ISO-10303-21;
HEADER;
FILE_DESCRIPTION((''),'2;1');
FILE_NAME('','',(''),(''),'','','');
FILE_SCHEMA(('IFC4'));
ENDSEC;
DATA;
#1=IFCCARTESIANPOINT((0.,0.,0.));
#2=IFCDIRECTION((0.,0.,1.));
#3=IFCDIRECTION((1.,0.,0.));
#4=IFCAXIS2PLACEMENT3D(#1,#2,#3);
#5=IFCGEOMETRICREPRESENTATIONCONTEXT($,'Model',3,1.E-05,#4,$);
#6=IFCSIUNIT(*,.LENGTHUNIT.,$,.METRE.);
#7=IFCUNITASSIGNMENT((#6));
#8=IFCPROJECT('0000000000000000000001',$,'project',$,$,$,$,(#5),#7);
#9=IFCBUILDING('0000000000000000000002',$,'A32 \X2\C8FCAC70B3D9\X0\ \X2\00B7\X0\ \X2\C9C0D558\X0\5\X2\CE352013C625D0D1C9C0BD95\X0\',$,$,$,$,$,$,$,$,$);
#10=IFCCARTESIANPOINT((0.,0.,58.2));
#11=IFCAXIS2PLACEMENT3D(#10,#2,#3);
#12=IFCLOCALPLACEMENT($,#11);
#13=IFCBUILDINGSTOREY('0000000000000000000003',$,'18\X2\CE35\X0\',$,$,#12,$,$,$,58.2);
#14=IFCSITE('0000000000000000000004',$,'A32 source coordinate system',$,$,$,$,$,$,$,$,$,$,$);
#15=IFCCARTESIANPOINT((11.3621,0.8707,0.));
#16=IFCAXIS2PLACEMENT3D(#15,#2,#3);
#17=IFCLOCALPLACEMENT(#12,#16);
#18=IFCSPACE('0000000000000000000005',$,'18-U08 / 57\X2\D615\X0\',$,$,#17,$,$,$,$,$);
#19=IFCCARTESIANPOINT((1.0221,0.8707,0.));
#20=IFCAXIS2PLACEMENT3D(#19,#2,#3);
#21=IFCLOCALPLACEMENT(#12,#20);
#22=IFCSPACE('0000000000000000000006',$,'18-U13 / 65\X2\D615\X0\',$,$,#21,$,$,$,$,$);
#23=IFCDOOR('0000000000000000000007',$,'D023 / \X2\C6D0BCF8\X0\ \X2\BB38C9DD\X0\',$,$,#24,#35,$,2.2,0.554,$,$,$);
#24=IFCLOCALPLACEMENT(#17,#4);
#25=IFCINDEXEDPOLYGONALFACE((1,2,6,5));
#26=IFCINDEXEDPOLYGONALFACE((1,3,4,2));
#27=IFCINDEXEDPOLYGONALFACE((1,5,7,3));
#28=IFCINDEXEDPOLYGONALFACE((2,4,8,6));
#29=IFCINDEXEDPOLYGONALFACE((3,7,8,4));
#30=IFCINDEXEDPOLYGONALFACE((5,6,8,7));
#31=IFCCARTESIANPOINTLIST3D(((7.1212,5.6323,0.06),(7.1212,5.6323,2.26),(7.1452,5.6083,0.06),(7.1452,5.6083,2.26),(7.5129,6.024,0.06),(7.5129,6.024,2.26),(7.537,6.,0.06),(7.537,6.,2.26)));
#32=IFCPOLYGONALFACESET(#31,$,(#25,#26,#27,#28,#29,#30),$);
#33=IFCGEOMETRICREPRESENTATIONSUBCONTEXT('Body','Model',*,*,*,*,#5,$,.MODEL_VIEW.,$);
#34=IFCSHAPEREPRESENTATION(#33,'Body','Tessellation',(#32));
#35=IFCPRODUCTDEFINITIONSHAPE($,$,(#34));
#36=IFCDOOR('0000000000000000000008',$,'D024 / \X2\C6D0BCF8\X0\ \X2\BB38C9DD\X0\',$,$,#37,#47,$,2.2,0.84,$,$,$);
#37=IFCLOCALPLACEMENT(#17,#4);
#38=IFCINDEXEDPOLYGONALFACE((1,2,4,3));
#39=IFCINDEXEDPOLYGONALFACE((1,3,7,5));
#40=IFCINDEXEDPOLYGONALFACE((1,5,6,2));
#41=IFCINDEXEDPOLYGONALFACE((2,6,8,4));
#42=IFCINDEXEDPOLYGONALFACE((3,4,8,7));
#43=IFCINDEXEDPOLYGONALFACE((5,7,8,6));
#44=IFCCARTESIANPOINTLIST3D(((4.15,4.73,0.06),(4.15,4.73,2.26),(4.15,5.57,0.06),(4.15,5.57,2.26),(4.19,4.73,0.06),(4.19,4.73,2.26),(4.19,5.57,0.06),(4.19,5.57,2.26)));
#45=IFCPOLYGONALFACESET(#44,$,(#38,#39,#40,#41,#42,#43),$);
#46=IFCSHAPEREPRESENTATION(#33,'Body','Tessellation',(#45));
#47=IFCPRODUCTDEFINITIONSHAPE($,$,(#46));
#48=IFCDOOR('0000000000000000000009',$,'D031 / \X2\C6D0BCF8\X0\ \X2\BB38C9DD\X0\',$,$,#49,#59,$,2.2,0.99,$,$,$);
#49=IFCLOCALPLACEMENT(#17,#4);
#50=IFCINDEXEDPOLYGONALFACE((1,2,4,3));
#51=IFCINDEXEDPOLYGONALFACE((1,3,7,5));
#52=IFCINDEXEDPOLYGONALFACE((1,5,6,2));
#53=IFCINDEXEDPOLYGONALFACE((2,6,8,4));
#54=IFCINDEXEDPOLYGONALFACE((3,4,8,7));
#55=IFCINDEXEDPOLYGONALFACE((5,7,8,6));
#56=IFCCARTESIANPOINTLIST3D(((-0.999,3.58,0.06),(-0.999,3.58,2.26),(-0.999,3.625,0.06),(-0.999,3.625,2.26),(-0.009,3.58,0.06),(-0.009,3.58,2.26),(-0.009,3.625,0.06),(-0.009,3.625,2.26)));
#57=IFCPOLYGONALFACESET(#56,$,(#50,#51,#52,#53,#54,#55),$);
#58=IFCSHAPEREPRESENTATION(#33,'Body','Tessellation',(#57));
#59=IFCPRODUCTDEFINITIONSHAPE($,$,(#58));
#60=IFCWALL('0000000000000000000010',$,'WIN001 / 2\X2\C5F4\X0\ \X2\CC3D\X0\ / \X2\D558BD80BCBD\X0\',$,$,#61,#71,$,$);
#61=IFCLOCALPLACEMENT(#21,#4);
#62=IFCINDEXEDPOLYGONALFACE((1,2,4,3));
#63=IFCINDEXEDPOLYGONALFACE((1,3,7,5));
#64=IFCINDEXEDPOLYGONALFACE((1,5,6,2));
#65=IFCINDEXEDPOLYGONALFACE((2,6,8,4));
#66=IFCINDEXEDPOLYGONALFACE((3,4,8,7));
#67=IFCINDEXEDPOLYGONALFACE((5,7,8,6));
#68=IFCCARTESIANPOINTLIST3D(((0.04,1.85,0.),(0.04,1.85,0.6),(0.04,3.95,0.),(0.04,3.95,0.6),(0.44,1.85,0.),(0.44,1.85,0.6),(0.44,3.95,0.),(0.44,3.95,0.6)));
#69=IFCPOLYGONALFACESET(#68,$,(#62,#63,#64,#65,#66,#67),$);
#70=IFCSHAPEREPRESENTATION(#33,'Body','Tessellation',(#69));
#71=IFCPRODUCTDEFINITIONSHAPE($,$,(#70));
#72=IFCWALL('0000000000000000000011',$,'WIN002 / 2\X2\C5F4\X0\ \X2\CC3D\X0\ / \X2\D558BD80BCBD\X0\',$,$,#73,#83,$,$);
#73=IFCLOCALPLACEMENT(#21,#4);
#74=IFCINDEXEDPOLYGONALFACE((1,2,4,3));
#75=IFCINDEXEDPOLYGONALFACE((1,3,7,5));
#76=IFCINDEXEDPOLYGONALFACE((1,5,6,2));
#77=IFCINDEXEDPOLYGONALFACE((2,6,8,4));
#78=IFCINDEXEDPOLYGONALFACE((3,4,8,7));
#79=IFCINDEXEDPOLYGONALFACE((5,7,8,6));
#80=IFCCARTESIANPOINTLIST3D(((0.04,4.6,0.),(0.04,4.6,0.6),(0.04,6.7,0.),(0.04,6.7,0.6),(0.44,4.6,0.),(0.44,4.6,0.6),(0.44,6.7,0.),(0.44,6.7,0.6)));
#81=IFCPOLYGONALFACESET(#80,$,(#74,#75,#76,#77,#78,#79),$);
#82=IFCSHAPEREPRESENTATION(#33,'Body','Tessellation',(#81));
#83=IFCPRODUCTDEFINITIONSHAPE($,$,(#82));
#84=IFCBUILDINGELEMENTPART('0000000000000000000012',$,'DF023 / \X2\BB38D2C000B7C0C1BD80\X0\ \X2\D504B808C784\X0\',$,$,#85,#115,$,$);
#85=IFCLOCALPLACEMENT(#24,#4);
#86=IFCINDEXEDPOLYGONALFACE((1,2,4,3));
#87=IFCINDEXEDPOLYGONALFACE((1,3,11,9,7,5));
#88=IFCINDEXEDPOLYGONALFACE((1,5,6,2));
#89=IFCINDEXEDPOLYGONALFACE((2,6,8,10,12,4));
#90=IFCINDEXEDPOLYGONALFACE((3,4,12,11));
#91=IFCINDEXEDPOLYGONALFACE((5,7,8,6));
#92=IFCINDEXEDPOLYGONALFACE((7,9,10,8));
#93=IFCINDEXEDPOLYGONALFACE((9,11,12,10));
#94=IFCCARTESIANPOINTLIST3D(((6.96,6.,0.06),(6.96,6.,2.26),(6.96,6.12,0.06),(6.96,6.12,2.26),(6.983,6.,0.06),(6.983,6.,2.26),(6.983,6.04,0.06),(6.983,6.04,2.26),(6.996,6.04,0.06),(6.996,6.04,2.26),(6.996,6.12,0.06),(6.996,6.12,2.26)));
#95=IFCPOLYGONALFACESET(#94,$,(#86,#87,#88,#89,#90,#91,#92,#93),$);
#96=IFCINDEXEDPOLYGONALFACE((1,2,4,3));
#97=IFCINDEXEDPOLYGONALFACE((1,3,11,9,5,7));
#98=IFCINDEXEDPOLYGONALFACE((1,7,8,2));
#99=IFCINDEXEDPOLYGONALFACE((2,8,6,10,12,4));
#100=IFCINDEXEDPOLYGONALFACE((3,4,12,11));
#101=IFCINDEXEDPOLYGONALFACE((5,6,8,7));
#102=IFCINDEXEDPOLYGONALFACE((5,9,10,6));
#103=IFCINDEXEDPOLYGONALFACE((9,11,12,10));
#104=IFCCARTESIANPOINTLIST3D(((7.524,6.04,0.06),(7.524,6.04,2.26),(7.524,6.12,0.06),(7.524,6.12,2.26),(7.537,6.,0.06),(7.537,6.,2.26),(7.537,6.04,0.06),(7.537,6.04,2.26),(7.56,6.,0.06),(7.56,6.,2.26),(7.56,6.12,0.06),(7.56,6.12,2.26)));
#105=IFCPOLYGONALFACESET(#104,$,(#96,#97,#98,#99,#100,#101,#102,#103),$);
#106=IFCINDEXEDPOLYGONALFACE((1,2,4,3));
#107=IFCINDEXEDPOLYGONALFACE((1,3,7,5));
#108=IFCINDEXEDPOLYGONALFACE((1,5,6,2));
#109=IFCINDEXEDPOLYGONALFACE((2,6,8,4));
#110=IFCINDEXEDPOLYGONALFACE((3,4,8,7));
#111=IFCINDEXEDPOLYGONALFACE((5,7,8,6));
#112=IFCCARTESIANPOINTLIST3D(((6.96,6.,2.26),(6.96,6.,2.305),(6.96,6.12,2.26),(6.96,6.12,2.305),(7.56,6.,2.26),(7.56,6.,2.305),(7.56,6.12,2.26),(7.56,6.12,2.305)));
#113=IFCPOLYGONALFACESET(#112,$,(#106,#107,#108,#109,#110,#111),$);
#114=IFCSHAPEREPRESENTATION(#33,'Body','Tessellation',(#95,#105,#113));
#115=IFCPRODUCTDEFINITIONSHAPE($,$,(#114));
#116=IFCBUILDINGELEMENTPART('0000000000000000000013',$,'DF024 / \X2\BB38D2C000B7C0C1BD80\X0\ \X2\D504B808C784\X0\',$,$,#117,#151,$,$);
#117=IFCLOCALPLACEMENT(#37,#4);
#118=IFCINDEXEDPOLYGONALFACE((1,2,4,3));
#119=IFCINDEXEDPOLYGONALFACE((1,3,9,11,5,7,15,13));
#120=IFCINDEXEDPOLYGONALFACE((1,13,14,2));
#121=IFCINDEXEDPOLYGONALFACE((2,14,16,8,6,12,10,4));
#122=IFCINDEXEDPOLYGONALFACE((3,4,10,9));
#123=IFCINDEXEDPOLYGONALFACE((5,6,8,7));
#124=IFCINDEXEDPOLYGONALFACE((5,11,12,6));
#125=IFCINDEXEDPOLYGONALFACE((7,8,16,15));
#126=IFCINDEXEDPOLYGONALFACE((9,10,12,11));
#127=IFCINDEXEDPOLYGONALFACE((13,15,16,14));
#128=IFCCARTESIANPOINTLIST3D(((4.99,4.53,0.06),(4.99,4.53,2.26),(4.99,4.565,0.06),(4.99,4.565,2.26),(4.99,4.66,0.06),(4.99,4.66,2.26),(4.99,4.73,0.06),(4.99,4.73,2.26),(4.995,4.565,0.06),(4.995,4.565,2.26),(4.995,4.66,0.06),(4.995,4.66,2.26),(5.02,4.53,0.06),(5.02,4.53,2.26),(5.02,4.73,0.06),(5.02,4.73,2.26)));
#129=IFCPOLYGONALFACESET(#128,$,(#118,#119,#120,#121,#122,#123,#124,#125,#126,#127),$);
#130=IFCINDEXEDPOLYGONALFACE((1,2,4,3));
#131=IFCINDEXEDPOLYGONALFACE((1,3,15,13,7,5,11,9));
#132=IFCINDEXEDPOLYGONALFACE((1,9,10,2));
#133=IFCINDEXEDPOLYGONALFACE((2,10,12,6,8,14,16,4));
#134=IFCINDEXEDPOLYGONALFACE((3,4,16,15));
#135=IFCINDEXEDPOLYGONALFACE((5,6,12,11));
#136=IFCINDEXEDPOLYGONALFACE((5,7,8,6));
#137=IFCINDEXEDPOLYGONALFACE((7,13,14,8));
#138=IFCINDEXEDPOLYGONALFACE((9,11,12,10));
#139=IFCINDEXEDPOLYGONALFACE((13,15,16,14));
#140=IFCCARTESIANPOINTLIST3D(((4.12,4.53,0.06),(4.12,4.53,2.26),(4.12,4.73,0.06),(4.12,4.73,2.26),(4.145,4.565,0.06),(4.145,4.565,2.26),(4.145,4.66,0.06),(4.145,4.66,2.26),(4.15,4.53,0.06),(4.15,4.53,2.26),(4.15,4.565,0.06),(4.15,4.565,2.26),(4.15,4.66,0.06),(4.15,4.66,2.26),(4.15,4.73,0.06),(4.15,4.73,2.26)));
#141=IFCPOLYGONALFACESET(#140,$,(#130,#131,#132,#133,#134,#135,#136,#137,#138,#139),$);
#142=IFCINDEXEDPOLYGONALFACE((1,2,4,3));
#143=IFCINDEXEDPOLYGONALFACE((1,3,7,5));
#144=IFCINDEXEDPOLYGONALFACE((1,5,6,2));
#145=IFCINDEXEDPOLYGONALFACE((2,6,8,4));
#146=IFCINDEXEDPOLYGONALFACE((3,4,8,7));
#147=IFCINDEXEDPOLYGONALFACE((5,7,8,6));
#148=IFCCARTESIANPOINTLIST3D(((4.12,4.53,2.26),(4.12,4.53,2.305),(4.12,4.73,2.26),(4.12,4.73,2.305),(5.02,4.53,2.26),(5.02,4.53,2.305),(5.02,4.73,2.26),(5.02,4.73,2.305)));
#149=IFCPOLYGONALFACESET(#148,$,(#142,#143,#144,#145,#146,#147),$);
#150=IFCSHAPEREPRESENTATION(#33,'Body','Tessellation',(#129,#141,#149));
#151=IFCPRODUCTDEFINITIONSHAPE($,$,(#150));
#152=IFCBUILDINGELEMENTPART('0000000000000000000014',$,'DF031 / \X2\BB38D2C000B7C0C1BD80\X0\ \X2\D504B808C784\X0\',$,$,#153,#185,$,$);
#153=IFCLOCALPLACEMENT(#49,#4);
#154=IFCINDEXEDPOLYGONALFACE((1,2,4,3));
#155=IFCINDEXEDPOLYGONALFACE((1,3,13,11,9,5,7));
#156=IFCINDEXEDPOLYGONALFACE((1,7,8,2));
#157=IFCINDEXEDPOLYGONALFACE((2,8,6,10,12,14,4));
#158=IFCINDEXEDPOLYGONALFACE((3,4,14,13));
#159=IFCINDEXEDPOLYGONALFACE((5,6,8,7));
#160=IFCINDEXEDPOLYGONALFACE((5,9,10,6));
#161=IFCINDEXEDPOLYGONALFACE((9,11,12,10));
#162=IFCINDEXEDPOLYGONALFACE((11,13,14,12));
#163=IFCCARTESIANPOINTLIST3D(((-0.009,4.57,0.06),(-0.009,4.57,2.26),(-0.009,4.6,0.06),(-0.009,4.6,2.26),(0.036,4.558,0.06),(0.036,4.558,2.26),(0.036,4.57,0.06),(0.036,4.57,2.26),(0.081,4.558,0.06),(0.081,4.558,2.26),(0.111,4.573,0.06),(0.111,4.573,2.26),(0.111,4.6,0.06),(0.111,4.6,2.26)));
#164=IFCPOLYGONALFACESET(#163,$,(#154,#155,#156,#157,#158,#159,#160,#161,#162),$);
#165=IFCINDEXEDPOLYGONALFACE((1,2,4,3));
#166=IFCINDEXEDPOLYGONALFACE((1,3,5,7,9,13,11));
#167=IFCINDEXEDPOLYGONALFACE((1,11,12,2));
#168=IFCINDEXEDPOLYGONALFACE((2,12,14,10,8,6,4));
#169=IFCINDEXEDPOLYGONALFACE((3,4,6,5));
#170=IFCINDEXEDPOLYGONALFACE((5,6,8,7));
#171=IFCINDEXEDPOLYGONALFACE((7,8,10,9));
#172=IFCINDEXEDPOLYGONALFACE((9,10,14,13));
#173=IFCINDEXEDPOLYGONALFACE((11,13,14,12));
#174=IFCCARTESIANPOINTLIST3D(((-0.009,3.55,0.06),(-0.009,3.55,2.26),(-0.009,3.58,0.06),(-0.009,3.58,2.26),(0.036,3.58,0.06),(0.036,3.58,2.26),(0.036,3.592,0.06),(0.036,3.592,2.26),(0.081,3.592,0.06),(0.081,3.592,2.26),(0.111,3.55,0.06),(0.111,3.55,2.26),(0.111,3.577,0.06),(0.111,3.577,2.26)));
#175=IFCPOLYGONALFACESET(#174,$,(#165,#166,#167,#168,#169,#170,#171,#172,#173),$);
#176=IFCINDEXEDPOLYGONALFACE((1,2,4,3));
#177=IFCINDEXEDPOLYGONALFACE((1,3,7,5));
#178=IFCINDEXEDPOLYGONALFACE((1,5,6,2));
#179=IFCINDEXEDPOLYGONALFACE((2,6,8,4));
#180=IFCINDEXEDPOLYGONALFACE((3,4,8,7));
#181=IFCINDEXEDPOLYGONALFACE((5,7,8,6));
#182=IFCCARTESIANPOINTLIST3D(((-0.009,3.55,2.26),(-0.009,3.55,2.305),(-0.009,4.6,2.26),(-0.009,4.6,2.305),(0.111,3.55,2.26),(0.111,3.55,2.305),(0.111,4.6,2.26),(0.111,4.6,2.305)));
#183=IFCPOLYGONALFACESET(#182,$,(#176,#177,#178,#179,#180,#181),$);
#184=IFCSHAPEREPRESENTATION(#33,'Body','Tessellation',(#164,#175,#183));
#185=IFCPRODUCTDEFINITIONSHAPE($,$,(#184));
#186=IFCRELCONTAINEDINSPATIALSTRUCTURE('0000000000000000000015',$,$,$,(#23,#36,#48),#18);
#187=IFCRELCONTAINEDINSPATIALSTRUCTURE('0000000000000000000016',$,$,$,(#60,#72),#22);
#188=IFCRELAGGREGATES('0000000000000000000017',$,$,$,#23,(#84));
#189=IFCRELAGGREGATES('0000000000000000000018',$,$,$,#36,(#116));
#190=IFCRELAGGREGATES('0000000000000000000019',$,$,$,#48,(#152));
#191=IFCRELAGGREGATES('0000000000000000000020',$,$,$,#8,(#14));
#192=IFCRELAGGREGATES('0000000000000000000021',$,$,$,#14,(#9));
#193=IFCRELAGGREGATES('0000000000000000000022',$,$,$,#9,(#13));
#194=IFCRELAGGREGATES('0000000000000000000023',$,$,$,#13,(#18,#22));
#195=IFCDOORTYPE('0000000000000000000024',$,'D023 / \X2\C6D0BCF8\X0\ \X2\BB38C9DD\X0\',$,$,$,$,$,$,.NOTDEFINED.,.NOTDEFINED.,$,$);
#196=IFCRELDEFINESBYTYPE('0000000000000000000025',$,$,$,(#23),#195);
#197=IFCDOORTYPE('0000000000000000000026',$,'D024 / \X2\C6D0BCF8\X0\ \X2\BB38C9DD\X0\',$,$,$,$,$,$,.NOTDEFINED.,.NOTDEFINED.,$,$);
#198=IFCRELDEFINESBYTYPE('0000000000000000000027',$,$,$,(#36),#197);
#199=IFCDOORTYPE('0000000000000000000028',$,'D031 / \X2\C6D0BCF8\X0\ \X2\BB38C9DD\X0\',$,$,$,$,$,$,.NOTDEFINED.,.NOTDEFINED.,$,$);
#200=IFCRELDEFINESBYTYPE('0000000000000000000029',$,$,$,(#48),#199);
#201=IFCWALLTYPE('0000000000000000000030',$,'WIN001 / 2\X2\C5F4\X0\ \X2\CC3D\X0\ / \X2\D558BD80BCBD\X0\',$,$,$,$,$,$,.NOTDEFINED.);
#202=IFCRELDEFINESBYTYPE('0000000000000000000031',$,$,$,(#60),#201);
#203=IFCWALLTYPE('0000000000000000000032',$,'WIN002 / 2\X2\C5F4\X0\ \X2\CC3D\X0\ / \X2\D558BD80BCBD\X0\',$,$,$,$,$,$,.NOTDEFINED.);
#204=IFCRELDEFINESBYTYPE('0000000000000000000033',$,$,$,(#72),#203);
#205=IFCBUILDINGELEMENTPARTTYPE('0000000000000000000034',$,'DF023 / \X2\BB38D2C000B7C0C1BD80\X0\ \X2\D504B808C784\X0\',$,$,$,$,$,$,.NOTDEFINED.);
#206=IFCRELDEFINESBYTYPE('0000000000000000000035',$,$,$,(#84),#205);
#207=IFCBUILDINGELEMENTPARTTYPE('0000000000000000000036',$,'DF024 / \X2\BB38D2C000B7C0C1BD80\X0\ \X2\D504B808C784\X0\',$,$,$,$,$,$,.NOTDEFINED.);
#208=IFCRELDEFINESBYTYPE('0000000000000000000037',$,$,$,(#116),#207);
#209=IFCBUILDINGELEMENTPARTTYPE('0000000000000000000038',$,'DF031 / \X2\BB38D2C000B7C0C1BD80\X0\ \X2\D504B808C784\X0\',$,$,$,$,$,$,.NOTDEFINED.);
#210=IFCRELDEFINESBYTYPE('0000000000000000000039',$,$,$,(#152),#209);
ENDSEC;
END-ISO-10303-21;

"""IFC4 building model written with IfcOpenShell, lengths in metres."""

from ifc_helpers import new_model, si_unit, frame, origin, origin_with_axes, place, context, subcontext, project, spatial, polyline, outline, extrude, source, transform, mapped, type_object, type_shapes, element, aggregate, save


model = new_model("IFC4")

# Units and contexts
model_context = context("Model", 3, precision=1e-05, world=origin_with_axes())
body_context = subcontext(model_context, "Body", "Model", "MODEL_VIEW")
ifc_project = project(units=[si_unit("LENGTHUNIT", "METRE")], contexts=[model_context])

# Site, building, storey, space
site = spatial("IfcSite", under=ifc_project, Name="A32 source coordinate system")
building = spatial("IfcBuilding", under=site, Name="A32 주거동 · 지하5층–옥탑지붕")
storey_placement = place(None, frame((0.0, 0.0, 58.2), z_axis=(0.0, 0.0, 1.0), x_axis=(1.0, 0.0, 0.0)))
storey = spatial("IfcBuildingStorey", under=building, at=storey_placement, Name="18층", Elevation=58.2)
space_1_placement = place(storey_placement, frame((11.3621, 0.8707, 0.0), z_axis=(0.0, 0.0, 1.0), x_axis=(1.0, 0.0, 0.0)))
space_1 = spatial("IfcSpace", under=storey, at=space_1_placement, Name="18-U08 / 57형")

# Doors
door_type_1 = type_object("IfcDoorType", Name="D023 / 원본 문짝", OperationType="NOTDEFINED", PredefinedType="NOTDEFINED")
shared_shape_1 = source(origin(), body_context, "Body", "SweptSolid", [
    extrude(outline(polyline([(7.537, 6.0), (7.1452, 5.6083), (7.1212, 5.6323), (7.5129, 6.024), (7.537, 6.0)])), frame((0.0, 0.0, 0.06)), (0.0, 0.0, 1.0), 2.2),
])
type_shapes(door_type_1, [shared_shape_1])
door_1_placement = place(space_1_placement, origin_with_axes())
door_1 = element("IfcDoor", 1, at=door_1_placement, inside=space_1, type_object=door_type_1, Name="D023 / 원본 문짝", OverallHeight=2.2, OverallWidth=0.554, context=body_context, shape_type="MappedRepresentation", body=[
    mapped(shared_shape_1, transform((0.0, 0.0, 0.0), scale=1.0)),
])
door_type_2 = type_object("IfcDoorType", Name="D024 / 원본 문짝", OperationType="NOTDEFINED", PredefinedType="NOTDEFINED")
shared_shape_2 = source(origin(), body_context, "Body", "SweptSolid", [
    extrude(outline(polyline([(4.15, 4.73), (4.15, 5.57), (4.19, 5.57), (4.19, 4.73), (4.15, 4.73)])), frame((0.0, 0.0, 0.06)), (0.0, 0.0, 1.0), 2.2),
])
type_shapes(door_type_2, [shared_shape_2])
door_2_placement = place(space_1_placement, origin_with_axes())
door_2 = element("IfcDoor", 2, at=door_2_placement, inside=space_1, type_object=door_type_2, Name="D024 / 원본 문짝", OverallHeight=2.2, OverallWidth=0.84, context=body_context, shape_type="MappedRepresentation", body=[
    mapped(shared_shape_2, transform((0.0, 0.0, 0.0), scale=1.0)),
])
door_type_3 = type_object("IfcDoorType", Name="D031 / 원본 문짝", OperationType="NOTDEFINED", PredefinedType="NOTDEFINED")
shared_shape_3 = source(origin(), body_context, "Body", "SweptSolid", [
    extrude(outline(polyline([(-0.009, 3.58), (-0.999, 3.58), (-0.999, 3.625), (-0.009, 3.625), (-0.009, 3.58)])), frame((0.0, 0.0, 0.06)), (0.0, 0.0, 1.0), 2.2),
])
type_shapes(door_type_3, [shared_shape_3])
door_3_placement = place(space_1_placement, origin_with_axes())
door_3 = element("IfcDoor", 3, at=door_3_placement, inside=space_1, type_object=door_type_3, Name="D031 / 원본 문짝", OverallHeight=2.2, OverallWidth=0.99, context=body_context, shape_type="MappedRepresentation", body=[
    mapped(shared_shape_3, transform((0.0, 0.0, 0.0), scale=1.0)),
])

# Shared definitions
space_2_placement = place(storey_placement, frame((1.0221, 0.8707, 0.0), z_axis=(0.0, 0.0, 1.0), x_axis=(1.0, 0.0, 0.0)))
space_2 = spatial("IfcSpace", under=storey, at=space_2_placement, Name="18-U13 / 65형")

# Walls
wall_type_1 = type_object("IfcWallType", Name="WIN001 / 2열 창 / 하부벽", PredefinedType="NOTDEFINED")
shared_shape_4 = source(origin(), body_context, "Body", "SweptSolid", [
    extrude(outline(polyline([(0.04, 3.95), (0.44, 3.95), (0.44, 1.85), (0.04, 1.85), (0.04, 3.95)])), origin(), (0.0, 0.0, 1.0), 0.6),
])
type_shapes(wall_type_1, [shared_shape_4])
wall_1_placement = place(space_2_placement, origin_with_axes())
element("IfcWall", 4, at=wall_1_placement, inside=space_2, type_object=wall_type_1, Name="WIN001 / 2열 창 / 하부벽", context=body_context, shape_type="MappedRepresentation", body=[
    mapped(shared_shape_4, transform((0.0, 0.0, 0.0), scale=1.0)),
])
wall_type_2 = type_object("IfcWallType", Name="WIN002 / 2열 창 / 하부벽", PredefinedType="NOTDEFINED")
shared_shape_5 = source(origin(), body_context, "Body", "SweptSolid", [
    extrude(outline(polyline([(0.04, 6.7), (0.44, 6.7), (0.44, 4.6), (0.04, 4.6), (0.04, 6.7)])), origin(), (0.0, 0.0, 1.0), 0.6),
])
type_shapes(wall_type_2, [shared_shape_5])
wall_2_placement = place(space_2_placement, origin_with_axes())
element("IfcWall", 5, at=wall_2_placement, inside=space_2, type_object=wall_type_2, Name="WIN002 / 2열 창 / 하부벽", context=body_context, shape_type="MappedRepresentation", body=[
    mapped(shared_shape_5, transform((0.0, 0.0, 0.0), scale=1.0)),
])

# Building element parts
building_element_part_type_1 = type_object("IfcBuildingElementPartType", Name="DF023 / 문틀·상부 프레임", PredefinedType="NOTDEFINED")
shared_shape_6 = source(origin(), body_context, "Body", "SweptSolid", [
    extrude(outline(polyline([(6.996, 6.12), (6.996, 6.04), (6.983, 6.04), (6.983, 6.0), (6.96, 6.0), (6.96, 6.12), (6.996, 6.12)])), frame((0.0, 0.0, 0.06)), (0.0, 0.0, 1.0), 2.2),
    extrude(outline(polyline([(7.56, 6.0), (7.537, 6.0), (7.537, 6.04), (7.524, 6.04), (7.524, 6.12), (7.56, 6.12), (7.56, 6.0)])), frame((0.0, 0.0, 0.06)), (0.0, 0.0, 1.0), 2.2),
    extrude(outline(polyline([(6.96, 6.0), (6.96, 6.12), (7.56, 6.12), (7.56, 6.0), (6.96, 6.0)])), frame((0.0, 0.0, 2.26)), (0.0, 0.0, 1.0), 0.045),
])
type_shapes(building_element_part_type_1, [shared_shape_6])
building_element_part_1_placement = place(door_1_placement, origin_with_axes())
building_element_part_1 = element("IfcBuildingElementPart", 6, at=building_element_part_1_placement, type_object=building_element_part_type_1, Name="DF023 / 문틀·상부 프레임", context=body_context, shape_type="MappedRepresentation", body=[
    mapped(shared_shape_6, transform((0.0, 0.0, 0.0), scale=1.0)),
])
aggregate(door_1, [building_element_part_1])
building_element_part_type_2 = type_object("IfcBuildingElementPartType", Name="DF024 / 문틀·상부 프레임", PredefinedType="NOTDEFINED")
shared_shape_7 = source(origin(), body_context, "Body", "SweptSolid", [
    extrude(outline(polyline([(5.02, 4.53), (4.99, 4.53), (4.99, 4.565), (4.995, 4.565), (4.995, 4.66), (4.99, 4.66), (4.99, 4.73), (5.02, 4.73), (5.02, 4.53)])), frame((0.0, 0.0, 0.06)), (0.0, 0.0, 1.0), 2.2),
    extrude(outline(polyline([(4.15, 4.73), (4.15, 4.66), (4.145, 4.66), (4.145, 4.565), (4.15, 4.565), (4.15, 4.53), (4.12, 4.53), (4.12, 4.73), (4.15, 4.73)])), frame((0.0, 0.0, 0.06)), (0.0, 0.0, 1.0), 2.2),
    extrude(outline(polyline([(4.12, 4.53), (4.12, 4.73), (5.02, 4.73), (5.02, 4.53), (4.12, 4.53)])), frame((0.0, 0.0, 2.26)), (0.0, 0.0, 1.0), 0.045),
])
type_shapes(building_element_part_type_2, [shared_shape_7])
building_element_part_2_placement = place(door_2_placement, origin_with_axes())
building_element_part_2 = element("IfcBuildingElementPart", 7, at=building_element_part_2_placement, type_object=building_element_part_type_2, Name="DF024 / 문틀·상부 프레임", context=body_context, shape_type="MappedRepresentation", body=[
    mapped(shared_shape_7, transform((0.0, 0.0, 0.0), scale=1.0)),
])
aggregate(door_2, [building_element_part_2])
building_element_part_type_3 = type_object("IfcBuildingElementPartType", Name="DF031 / 문틀·상부 프레임", PredefinedType="NOTDEFINED")
shared_shape_8 = source(origin(), body_context, "Body", "SweptSolid", [
    extrude(outline(polyline([(0.111, 4.6), (0.111, 4.573), (0.081, 4.558), (0.036, 4.558), (0.036, 4.57), (-0.009, 4.57), (-0.009, 4.6), (0.111, 4.6)])), frame((0.0, 0.0, 0.06)), (0.0, 0.0, 1.0), 2.2),
    extrude(outline(polyline([(-0.009, 3.58), (0.036, 3.58), (0.036, 3.592), (0.081, 3.592), (0.111, 3.577), (0.111, 3.55), (-0.009, 3.55), (-0.009, 3.58)])), frame((0.0, 0.0, 0.06)), (0.0, 0.0, 1.0), 2.2),
    extrude(outline(polyline([(-0.009, 3.55), (-0.009, 4.6), (0.111, 4.6), (0.111, 3.55), (-0.009, 3.55)])), frame((0.0, 0.0, 2.26)), (0.0, 0.0, 1.0), 0.045),
])
type_shapes(building_element_part_type_3, [shared_shape_8])
building_element_part_3_placement = place(door_3_placement, origin_with_axes())
building_element_part_3 = element("IfcBuildingElementPart", 8, at=building_element_part_3_placement, type_object=building_element_part_type_3, Name="DF031 / 문틀·상부 프레임", context=body_context, shape_type="MappedRepresentation", body=[
    mapped(shared_shape_8, transform((0.0, 0.0, 0.0), scale=1.0)),
])
aggregate(door_3, [building_element_part_3])

save(model, "model.ifc")
